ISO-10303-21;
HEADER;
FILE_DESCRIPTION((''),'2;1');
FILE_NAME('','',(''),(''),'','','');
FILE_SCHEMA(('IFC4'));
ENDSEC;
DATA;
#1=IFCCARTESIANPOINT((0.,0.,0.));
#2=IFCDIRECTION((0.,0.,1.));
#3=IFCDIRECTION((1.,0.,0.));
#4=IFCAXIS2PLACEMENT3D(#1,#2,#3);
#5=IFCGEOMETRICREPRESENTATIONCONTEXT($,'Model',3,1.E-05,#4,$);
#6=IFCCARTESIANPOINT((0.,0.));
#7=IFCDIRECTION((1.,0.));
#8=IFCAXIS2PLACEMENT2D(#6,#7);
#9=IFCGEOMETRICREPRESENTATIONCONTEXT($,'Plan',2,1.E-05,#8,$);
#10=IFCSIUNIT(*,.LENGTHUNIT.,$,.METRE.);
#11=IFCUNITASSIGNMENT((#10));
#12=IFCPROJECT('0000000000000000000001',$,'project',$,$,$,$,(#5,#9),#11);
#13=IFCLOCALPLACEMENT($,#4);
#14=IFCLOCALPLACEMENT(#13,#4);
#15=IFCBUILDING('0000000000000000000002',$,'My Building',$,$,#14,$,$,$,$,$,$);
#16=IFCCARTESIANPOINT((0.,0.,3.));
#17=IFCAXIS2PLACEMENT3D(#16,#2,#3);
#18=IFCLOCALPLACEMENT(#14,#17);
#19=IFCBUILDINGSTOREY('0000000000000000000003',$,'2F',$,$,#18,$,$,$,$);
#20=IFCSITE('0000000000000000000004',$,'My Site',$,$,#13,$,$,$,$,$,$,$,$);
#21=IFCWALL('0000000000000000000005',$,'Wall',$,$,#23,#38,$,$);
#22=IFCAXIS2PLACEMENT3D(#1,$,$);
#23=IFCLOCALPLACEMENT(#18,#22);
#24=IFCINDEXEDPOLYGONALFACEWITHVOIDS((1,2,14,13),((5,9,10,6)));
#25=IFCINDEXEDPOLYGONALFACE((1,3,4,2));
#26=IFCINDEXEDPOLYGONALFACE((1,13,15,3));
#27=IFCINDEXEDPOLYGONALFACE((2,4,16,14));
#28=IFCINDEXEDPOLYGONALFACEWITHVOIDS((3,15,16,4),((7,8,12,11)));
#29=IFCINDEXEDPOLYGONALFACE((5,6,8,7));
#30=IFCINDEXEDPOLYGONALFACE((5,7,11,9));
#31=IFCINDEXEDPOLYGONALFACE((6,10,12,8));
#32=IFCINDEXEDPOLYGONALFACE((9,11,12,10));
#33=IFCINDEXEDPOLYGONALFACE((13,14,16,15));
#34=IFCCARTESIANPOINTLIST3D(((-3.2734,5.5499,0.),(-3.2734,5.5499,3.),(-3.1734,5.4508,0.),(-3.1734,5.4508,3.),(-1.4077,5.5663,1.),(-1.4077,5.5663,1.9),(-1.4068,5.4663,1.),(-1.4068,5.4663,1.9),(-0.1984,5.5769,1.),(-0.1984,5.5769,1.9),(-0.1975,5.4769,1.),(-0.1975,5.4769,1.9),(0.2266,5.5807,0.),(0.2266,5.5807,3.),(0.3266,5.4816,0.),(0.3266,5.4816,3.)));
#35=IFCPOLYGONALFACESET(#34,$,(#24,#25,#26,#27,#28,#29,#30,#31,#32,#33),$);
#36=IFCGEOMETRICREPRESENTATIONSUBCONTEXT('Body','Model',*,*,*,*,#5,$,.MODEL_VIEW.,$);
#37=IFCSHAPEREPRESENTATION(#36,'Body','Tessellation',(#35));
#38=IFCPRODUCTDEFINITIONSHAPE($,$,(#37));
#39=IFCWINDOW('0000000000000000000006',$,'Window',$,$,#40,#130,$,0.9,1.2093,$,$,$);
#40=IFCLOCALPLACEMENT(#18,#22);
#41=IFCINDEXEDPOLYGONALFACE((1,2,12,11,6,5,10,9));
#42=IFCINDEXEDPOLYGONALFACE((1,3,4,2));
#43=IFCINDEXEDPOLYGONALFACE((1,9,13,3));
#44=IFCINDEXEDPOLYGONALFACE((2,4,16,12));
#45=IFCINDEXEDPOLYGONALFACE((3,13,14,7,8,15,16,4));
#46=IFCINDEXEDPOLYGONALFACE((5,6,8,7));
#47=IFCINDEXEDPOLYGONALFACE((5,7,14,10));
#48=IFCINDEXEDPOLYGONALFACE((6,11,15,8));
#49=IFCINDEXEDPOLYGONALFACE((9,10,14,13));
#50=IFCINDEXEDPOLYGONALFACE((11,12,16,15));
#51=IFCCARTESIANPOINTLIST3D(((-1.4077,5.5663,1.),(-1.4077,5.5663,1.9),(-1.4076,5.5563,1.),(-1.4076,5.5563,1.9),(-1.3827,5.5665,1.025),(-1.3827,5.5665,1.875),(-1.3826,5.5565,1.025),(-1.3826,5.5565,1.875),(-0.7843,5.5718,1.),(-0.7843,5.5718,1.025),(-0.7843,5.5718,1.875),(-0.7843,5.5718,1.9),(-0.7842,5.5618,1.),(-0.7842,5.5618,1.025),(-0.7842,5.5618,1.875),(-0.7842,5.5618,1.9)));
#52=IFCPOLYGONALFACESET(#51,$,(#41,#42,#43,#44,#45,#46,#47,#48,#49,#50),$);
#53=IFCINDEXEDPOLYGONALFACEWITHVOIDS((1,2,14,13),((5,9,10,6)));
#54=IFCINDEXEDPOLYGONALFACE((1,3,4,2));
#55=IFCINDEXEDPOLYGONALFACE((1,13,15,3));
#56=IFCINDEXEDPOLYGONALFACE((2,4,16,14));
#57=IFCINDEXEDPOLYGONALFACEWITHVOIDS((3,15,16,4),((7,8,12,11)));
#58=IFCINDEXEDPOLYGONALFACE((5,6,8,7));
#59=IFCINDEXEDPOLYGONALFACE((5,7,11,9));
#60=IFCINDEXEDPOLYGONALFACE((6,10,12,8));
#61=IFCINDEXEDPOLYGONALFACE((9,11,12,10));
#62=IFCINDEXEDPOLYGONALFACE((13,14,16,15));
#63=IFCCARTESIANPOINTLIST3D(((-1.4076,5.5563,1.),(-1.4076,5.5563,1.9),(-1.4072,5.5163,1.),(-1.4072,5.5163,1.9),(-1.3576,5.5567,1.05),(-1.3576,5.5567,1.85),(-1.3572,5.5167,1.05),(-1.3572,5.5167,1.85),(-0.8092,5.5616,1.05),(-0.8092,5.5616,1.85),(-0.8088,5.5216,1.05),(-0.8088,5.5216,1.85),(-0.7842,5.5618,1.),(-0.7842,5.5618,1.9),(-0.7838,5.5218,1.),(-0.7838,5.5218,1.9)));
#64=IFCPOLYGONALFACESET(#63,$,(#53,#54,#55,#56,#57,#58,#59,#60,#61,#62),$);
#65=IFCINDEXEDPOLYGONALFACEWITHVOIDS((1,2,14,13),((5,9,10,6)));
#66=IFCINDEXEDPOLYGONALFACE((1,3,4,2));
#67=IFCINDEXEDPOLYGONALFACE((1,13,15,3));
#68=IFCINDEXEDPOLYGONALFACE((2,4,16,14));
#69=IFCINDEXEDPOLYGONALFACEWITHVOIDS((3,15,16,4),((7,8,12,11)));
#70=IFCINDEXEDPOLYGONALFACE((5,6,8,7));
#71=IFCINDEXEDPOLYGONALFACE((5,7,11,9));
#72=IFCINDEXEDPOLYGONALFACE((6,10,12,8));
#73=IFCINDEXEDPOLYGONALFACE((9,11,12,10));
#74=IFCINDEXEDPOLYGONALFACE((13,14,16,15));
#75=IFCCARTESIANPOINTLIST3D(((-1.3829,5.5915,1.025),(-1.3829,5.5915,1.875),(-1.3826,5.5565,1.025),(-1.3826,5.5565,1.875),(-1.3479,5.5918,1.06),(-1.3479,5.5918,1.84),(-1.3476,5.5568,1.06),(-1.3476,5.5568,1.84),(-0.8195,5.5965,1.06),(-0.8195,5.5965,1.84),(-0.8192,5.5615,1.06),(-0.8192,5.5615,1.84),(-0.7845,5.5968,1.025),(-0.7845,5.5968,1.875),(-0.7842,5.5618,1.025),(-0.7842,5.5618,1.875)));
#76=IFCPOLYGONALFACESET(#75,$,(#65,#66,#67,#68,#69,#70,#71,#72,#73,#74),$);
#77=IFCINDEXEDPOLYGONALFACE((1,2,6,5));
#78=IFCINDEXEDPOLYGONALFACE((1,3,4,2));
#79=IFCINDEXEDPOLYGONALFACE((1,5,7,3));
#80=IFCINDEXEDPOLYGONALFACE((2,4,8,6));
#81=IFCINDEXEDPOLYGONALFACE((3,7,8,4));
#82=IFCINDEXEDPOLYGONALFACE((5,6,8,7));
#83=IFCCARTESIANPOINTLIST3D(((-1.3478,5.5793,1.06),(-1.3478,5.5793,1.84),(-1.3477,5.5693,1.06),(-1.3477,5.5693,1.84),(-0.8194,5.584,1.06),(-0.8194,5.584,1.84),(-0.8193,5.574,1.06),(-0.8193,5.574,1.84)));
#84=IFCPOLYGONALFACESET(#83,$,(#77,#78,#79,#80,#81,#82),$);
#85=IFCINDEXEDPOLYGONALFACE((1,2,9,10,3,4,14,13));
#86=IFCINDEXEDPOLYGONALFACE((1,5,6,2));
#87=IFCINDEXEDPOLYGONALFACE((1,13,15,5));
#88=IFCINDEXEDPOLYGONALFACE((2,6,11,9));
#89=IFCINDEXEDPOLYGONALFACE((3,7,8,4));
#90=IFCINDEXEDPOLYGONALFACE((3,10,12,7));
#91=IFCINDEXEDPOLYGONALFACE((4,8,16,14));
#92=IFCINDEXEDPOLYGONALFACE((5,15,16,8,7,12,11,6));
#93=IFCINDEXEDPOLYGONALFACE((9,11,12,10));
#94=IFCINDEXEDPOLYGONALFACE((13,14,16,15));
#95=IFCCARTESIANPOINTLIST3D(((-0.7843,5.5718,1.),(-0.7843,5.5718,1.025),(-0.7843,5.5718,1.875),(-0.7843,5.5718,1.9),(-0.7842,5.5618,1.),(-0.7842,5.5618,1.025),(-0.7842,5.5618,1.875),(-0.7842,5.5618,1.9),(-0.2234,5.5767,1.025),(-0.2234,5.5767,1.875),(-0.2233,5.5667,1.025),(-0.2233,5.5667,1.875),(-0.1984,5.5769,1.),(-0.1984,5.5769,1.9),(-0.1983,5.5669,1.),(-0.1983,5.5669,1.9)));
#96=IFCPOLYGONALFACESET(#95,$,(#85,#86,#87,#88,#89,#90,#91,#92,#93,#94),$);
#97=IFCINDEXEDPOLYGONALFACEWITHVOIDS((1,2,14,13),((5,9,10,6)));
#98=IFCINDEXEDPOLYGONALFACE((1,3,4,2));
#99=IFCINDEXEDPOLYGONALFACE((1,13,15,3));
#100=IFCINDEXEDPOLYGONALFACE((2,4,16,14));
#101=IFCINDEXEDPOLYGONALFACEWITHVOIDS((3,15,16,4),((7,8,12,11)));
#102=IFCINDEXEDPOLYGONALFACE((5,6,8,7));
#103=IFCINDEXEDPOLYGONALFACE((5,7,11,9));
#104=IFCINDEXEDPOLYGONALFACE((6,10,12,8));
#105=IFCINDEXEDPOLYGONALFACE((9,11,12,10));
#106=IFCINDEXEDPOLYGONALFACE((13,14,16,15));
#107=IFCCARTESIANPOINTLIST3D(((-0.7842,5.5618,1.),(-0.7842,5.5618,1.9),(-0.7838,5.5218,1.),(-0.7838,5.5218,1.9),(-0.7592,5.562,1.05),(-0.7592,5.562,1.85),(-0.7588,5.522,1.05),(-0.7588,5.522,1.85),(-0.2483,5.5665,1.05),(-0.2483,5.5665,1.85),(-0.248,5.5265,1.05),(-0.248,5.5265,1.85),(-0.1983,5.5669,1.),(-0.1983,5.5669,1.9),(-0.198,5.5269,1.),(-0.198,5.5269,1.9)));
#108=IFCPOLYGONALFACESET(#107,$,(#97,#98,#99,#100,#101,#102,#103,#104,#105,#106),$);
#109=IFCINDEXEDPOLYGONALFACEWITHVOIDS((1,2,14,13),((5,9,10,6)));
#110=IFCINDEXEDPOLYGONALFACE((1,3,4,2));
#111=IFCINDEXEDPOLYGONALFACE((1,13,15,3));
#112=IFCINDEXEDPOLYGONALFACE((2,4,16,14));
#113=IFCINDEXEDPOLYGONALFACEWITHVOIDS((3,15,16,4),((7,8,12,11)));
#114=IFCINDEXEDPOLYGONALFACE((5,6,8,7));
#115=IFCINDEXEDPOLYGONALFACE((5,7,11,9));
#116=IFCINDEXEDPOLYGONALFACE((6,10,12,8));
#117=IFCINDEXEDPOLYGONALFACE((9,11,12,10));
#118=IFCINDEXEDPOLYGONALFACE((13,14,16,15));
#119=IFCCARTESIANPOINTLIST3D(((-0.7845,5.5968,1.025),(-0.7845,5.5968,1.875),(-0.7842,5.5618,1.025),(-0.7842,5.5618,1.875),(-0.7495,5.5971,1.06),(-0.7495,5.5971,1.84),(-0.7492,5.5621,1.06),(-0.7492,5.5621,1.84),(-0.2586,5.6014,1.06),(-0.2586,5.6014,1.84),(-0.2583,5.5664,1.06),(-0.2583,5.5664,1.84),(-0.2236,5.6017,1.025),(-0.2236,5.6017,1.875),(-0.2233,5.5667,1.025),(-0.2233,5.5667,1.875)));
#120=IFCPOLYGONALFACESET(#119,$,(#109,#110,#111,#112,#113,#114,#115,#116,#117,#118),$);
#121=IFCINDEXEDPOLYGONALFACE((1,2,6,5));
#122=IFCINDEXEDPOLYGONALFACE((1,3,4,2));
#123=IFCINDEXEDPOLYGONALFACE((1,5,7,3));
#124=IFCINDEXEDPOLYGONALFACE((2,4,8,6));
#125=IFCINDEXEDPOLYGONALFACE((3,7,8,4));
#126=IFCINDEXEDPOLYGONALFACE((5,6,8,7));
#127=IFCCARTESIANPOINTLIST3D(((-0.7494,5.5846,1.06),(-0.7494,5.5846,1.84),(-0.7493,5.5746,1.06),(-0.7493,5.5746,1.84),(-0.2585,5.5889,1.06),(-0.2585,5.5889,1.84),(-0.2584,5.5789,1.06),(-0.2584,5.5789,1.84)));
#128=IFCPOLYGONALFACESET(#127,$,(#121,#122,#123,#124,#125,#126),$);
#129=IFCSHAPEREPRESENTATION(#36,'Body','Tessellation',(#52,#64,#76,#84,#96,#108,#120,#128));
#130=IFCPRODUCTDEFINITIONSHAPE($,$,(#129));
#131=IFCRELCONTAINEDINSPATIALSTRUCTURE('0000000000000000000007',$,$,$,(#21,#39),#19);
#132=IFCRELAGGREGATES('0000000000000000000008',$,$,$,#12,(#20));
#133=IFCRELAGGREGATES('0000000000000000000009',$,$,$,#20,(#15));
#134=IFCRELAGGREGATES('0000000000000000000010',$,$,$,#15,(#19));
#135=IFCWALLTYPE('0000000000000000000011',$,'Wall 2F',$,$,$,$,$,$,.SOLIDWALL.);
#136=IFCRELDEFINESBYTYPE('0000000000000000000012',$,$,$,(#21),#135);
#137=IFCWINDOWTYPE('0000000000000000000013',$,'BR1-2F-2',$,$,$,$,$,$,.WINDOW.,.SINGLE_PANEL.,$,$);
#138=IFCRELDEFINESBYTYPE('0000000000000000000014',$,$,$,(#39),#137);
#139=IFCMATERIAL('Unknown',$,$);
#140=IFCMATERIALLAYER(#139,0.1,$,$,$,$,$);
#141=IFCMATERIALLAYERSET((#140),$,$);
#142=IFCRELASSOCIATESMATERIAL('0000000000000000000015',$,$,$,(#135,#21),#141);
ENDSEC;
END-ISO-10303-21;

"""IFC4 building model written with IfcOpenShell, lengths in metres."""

from ifc_helpers import new_model, entity, si_unit, frame, origin_with_axes, origin_2d_with_axis, place, context, subcontext, project, spatial, line, indexed_curve, outline, extrude, shape, source, transform, mapped, material, layer, layer_set, layer_usage, type_object, type_shapes, element, fill, save


model = new_model("IFC4")

# Units and contexts
model_context = context("Model", 3, precision=1e-05, world=origin_with_axes())
plan_context = context("Plan", 2, precision=1e-05, world=origin_2d_with_axis())
body_context_1 = subcontext(model_context, "Body", "Model", "MODEL_VIEW")
body_context_2 = subcontext(plan_context, "Body", "Plan", "PLAN_VIEW")
ifc_project = project(units=[si_unit("LENGTHUNIT", "METRE")], contexts=[model_context, plan_context])

# Site, building, storey
site_placement = place(None, origin_with_axes())
site = spatial("IfcSite", under=ifc_project, at=site_placement, Name="My Site")
building_placement = place(site_placement, origin_with_axes())
building = spatial("IfcBuilding", under=site, at=building_placement, Name="My Building")
storey_placement = place(building_placement, frame((0.0, 0.0, 3.0), z_axis=(0.0, 0.0, 1.0), x_axis=(1.0, 0.0, 0.0)))
storey = spatial("IfcBuildingStorey", under=building, at=storey_placement, Name="2F")

# Shared definitions
ifc_material = material(Name="Unknown")

# Shared definitions
ifc_layer = layer(ifc_material, 0.1)
ifc_layer_set = layer_set([ifc_layer])
wall_type = type_object("IfcWallType", Name="Wall 2F", PredefinedType="SOLIDWALL", material=ifc_layer_set)

# Wall, opening, window
ifc_layer_usage_1 = layer_usage(ifc_layer_set, "AXIS2", "POSITIVE", 0.0)
wall_1_placement = place(storey_placement, frame((0.2266, 5.5807, 0.0), z_axis=(0.0, 0.0, 1.0), x_axis=(-0.999961, -0.008796, 0.0)))
wall_1 = element("IfcWall", 1, at=wall_1_placement, inside=storey, type_object=wall_type, material=ifc_layer_usage_1, Name="Wall", context=body_context_1, shape_type="SweptSolid", body=[
    extrude(outline(indexed_curve([(0.0, 0.0), (-0.0991, 0.1), (3.401, 0.1), (3.5001, 0.0)], segments=[line(1, 2, 3, 4, 1)])), origin_with_axes(), (0.0, 0.0, 1.0), 3.0),
])
shared_shape_1 = source(origin_with_axes(), body_context_1, "Body", "SweptSolid", [
    extrude(outline(indexed_curve([(0.0, 0.0), (1.2093, 0.0), (1.2093, 0.9), (0.0, 0.9)], segments=[line(1, 2, 3, 4, 1)])), frame((0.0, -0.6, 0.0), z_axis=(0.0, -1.0, 0.0), x_axis=(1.0, 0.0, 0.0)), (0.0, 0.0, -1.0), 1.2),
])
opening_1_placement = place(wall_1_placement, frame((1.6343, 0.1, 1.0), z_axis=(0.0, 0.0, 1.0), x_axis=(-1.0, 0.0, 0.0)))
opening_1 = element("IfcOpeningElement", 2, at=opening_1_placement, cuts=wall_1, PredefinedType="OPENING", context=body_context_1, shape_type="MappedRepresentation", body=[
    mapped(shared_shape_1, transform((0.0, 0.0, 0.0), x_axis=(1.0, 0.0, 0.0), y_axis=(0.0, 1.0, 0.0), z_axis=(0.0, 0.0, 1.0), scale=1.0)),
])
window_type_1 = type_object("IfcWindowType", Name="BR1-2F-2", PartitioningType="SINGLE_PANEL", PredefinedType="WINDOW")
shared_shape_2 = source(origin_with_axes(), body_context_1, "Body", "SweptSolid", [
    extrude(outline(indexed_curve([(0.6234, 0.0), (0.0, 0.0), (0.0, 0.9), (0.6234, 0.9), (0.6234, 0.875), (0.025, 0.875), (0.025, 0.025), (0.6234, 0.025)], segments=[line(1, 2, 3, 4, 5, 6, 7, 8, 1)])), frame((0.0, 0.09, 0.0), z_axis=(0.0, -1.0, 0.0), x_axis=(1.0, 0.0, 0.0)), (0.0, 0.0, -1.0), 0.01),
    extrude(outline(indexed_curve([(0.0, 0.0), (0.6234, 0.0), (0.6234, 0.9), (0.0, 0.9)], segments=[line(1, 2, 3, 4, 1)]), holes=[indexed_curve([(0.05, 0.05), (0.5984, 0.05), (0.5984, 0.85), (0.05, 0.85)], segments=[line(1, 2, 3, 4, 1)])]), frame((0.0, 0.05, 0.0), z_axis=(0.0, -1.0, 0.0), x_axis=(1.0, 0.0, 0.0)), (0.0, 0.0, -1.0), 0.04),
    extrude(outline(indexed_curve([(0.0, 0.0), (0.5984, 0.0), (0.5984, 0.85), (0.0, 0.85)], segments=[line(1, 2, 3, 4, 1)]), holes=[indexed_curve([(0.035, 0.035), (0.5634, 0.035), (0.5634, 0.815), (0.035, 0.815)], segments=[line(1, 2, 3, 4, 1)])]), frame((0.025, 0.09, 0.025), z_axis=(0.0, -1.0, 0.0), x_axis=(1.0, 0.0, 0.0)), (0.0, 0.0, -1.0), 0.035),
    extrude(outline(indexed_curve([(0.035, 0.035), (0.5634, 0.035), (0.5634, 0.815), (0.035, 0.815)], segments=[line(1, 2, 3, 4, 1)])), frame((0.025, 0.1025, 0.025), z_axis=(0.0, -1.0, 0.0), x_axis=(1.0, 0.0, 0.0)), (0.0, 0.0, -1.0), 0.01),
    extrude(outline(indexed_curve([(0.0, 0.9), (0.5859, 0.9), (0.5859, 0.0), (0.0, 0.0), (0.0, 0.025), (0.5609, 0.025), (0.5609, 0.875), (0.0, 0.875)], segments=[line(1, 2, 3, 4, 5, 6, 7, 8, 1)])), frame((0.6234, 0.09, 0.0), z_axis=(0.0, -1.0, 0.0), x_axis=(1.0, 0.0, 0.0)), (0.0, 0.0, -1.0), 0.01),
    extrude(outline(indexed_curve([(0.0, 0.0), (0.5859, 0.0), (0.5859, 0.9), (0.0, 0.9)], segments=[line(1, 2, 3, 4, 1)]), holes=[indexed_curve([(0.025, 0.05), (0.5359, 0.05), (0.5359, 0.85), (0.025, 0.85)], segments=[line(1, 2, 3, 4, 1)])]), frame((0.6234, 0.05, 0.0), z_axis=(0.0, -1.0, 0.0), x_axis=(1.0, 0.0, 0.0)), (0.0, 0.0, -1.0), 0.04),
    extrude(outline(indexed_curve([(0.0, 0.0), (0.5609, 0.0), (0.5609, 0.85), (0.0, 0.85)], segments=[line(1, 2, 3, 4, 1)]), holes=[indexed_curve([(0.035, 0.035), (0.5259, 0.035), (0.5259, 0.815), (0.035, 0.815)], segments=[line(1, 2, 3, 4, 1)])]), frame((0.6234, 0.09, 0.025), z_axis=(0.0, -1.0, 0.0), x_axis=(1.0, 0.0, 0.0)), (0.0, 0.0, -1.0), 0.035),
    extrude(outline(indexed_curve([(0.035, 0.035), (0.5259, 0.035), (0.5259, 0.815), (0.035, 0.815)], segments=[line(1, 2, 3, 4, 1)])), frame((0.6234, 0.1025, 0.025), z_axis=(0.0, -1.0, 0.0), x_axis=(1.0, 0.0, 0.0)), (0.0, 0.0, -1.0), 0.01),
])
shared_shape_3 = source(origin_with_axes(), body_context_2, "Body", "Curve2D", [
    entity("IfcIndexedPolyCurve", entity("IfcCartesianPointList2D", [[0.05, 0.05], [0.5984, 0.05]])),
    entity("IfcIndexedPolyCurve", entity("IfcCartesianPointList2D", [[0.0, 0.1], [0.025, 0.1], [0.025, 0.09], [0.05, 0.09], [0.05, 0.05], [0.0, 0.05]]), [entity("IfcLineIndex", [1, 2, 3, 4, 5, 6, 1])]),
    entity("IfcIndexedPolyCurve", entity("IfcCartesianPointList2D", [[0.6234, 0.1], [0.6234, 0.1], [0.6234, 0.09], [0.5984, 0.09], [0.5984, 0.05], [0.6234, 0.05]])),
    entity("IfcIndexedPolyCurve", entity("IfcCartesianPointList2D", [[0.025, 0.09], [0.06, 0.09], [0.06, 0.125], [0.025, 0.125]]), [entity("IfcLineIndex", [1, 2, 3, 4, 1])]),
    entity("IfcIndexedPolyCurve", entity("IfcCartesianPointList2D", [[0.6234, 0.09], [0.5884, 0.09], [0.5884, 0.125], [0.6234, 0.125]]), [entity("IfcLineIndex", [1, 2, 3, 4, 1])]),
    entity("IfcIndexedPolyCurve", entity("IfcCartesianPointList2D", [[0.06, 0.09], [0.5884, 0.09]])),
    entity("IfcIndexedPolyCurve", entity("IfcCartesianPointList2D", [[0.06, 0.125], [0.5884, 0.125]])),
    entity("IfcIndexedPolyCurve", entity("IfcCartesianPointList2D", [[0.06, 0.1075], [0.5884, 0.1075]])),
    entity("IfcIndexedPolyCurve", entity("IfcCartesianPointList2D", [[0.6484, 0.05], [1.1593, 0.05]])),
    entity("IfcIndexedPolyCurve", entity("IfcCartesianPointList2D", [[0.6234, 0.1], [0.6234, 0.1], [0.6234, 0.09], [0.6484, 0.09], [0.6484, 0.05], [0.6234, 0.05]])),
    entity("IfcIndexedPolyCurve", entity("IfcCartesianPointList2D", [[1.2093, 0.1], [1.1843, 0.1], [1.1843, 0.09], [1.1593, 0.09], [1.1593, 0.05], [1.2093, 0.05]]), [entity("IfcLineIndex", [1, 2, 3, 4, 5, 6, 1])]),
    entity("IfcIndexedPolyCurve", entity("IfcCartesianPointList2D", [[0.6234, 0.09], [0.6584, 0.09], [0.6584, 0.125], [0.6234, 0.125]]), [entity("IfcLineIndex", [1, 2, 3, 4, 1])]),
    entity("IfcIndexedPolyCurve", entity("IfcCartesianPointList2D", [[1.1843, 0.09], [1.1493, 0.09], [1.1493, 0.125], [1.1843, 0.125]]), [entity("IfcLineIndex", [1, 2, 3, 4, 1])]),
    entity("IfcIndexedPolyCurve", entity("IfcCartesianPointList2D", [[0.6584, 0.09], [1.1493, 0.09]])),
    entity("IfcIndexedPolyCurve", entity("IfcCartesianPointList2D", [[0.6584, 0.125], [1.1493, 0.125]])),
    entity("IfcIndexedPolyCurve", entity("IfcCartesianPointList2D", [[0.6584, 0.1075], [1.1493, 0.1075]])),
])
type_shapes(window_type_1, [shared_shape_2, shared_shape_3])
window_1_placement = place(opening_1_placement, origin_with_axes())
window_1 = element("IfcWindow", 3, at=window_1_placement, inside=storey, type_object=window_type_1, Name="Window", OverallHeight=0.9, OverallWidth=1.2093, shapes=[
    shape(body_context_1, "Body", "MappedRepresentation", [mapped(shared_shape_2, transform((0.0, 0.0, 0.0), x_axis=(1.0, 0.0, 0.0), y_axis=(0.0, 1.0, 0.0), z_axis=(0.0, 0.0, 1.0), scale=1.0))]),
    shape(body_context_2, "Body", "MappedRepresentation", [mapped(shared_shape_3, transform((0.0, 0.0, 0.0), x_axis=(1.0, 0.0, 0.0), y_axis=(0.0, 1.0, 0.0), z_axis=(0.0, 0.0, 1.0), scale=1.0))]),
])
fill(opening_1, window_1)

save(model, "model.ifc")
